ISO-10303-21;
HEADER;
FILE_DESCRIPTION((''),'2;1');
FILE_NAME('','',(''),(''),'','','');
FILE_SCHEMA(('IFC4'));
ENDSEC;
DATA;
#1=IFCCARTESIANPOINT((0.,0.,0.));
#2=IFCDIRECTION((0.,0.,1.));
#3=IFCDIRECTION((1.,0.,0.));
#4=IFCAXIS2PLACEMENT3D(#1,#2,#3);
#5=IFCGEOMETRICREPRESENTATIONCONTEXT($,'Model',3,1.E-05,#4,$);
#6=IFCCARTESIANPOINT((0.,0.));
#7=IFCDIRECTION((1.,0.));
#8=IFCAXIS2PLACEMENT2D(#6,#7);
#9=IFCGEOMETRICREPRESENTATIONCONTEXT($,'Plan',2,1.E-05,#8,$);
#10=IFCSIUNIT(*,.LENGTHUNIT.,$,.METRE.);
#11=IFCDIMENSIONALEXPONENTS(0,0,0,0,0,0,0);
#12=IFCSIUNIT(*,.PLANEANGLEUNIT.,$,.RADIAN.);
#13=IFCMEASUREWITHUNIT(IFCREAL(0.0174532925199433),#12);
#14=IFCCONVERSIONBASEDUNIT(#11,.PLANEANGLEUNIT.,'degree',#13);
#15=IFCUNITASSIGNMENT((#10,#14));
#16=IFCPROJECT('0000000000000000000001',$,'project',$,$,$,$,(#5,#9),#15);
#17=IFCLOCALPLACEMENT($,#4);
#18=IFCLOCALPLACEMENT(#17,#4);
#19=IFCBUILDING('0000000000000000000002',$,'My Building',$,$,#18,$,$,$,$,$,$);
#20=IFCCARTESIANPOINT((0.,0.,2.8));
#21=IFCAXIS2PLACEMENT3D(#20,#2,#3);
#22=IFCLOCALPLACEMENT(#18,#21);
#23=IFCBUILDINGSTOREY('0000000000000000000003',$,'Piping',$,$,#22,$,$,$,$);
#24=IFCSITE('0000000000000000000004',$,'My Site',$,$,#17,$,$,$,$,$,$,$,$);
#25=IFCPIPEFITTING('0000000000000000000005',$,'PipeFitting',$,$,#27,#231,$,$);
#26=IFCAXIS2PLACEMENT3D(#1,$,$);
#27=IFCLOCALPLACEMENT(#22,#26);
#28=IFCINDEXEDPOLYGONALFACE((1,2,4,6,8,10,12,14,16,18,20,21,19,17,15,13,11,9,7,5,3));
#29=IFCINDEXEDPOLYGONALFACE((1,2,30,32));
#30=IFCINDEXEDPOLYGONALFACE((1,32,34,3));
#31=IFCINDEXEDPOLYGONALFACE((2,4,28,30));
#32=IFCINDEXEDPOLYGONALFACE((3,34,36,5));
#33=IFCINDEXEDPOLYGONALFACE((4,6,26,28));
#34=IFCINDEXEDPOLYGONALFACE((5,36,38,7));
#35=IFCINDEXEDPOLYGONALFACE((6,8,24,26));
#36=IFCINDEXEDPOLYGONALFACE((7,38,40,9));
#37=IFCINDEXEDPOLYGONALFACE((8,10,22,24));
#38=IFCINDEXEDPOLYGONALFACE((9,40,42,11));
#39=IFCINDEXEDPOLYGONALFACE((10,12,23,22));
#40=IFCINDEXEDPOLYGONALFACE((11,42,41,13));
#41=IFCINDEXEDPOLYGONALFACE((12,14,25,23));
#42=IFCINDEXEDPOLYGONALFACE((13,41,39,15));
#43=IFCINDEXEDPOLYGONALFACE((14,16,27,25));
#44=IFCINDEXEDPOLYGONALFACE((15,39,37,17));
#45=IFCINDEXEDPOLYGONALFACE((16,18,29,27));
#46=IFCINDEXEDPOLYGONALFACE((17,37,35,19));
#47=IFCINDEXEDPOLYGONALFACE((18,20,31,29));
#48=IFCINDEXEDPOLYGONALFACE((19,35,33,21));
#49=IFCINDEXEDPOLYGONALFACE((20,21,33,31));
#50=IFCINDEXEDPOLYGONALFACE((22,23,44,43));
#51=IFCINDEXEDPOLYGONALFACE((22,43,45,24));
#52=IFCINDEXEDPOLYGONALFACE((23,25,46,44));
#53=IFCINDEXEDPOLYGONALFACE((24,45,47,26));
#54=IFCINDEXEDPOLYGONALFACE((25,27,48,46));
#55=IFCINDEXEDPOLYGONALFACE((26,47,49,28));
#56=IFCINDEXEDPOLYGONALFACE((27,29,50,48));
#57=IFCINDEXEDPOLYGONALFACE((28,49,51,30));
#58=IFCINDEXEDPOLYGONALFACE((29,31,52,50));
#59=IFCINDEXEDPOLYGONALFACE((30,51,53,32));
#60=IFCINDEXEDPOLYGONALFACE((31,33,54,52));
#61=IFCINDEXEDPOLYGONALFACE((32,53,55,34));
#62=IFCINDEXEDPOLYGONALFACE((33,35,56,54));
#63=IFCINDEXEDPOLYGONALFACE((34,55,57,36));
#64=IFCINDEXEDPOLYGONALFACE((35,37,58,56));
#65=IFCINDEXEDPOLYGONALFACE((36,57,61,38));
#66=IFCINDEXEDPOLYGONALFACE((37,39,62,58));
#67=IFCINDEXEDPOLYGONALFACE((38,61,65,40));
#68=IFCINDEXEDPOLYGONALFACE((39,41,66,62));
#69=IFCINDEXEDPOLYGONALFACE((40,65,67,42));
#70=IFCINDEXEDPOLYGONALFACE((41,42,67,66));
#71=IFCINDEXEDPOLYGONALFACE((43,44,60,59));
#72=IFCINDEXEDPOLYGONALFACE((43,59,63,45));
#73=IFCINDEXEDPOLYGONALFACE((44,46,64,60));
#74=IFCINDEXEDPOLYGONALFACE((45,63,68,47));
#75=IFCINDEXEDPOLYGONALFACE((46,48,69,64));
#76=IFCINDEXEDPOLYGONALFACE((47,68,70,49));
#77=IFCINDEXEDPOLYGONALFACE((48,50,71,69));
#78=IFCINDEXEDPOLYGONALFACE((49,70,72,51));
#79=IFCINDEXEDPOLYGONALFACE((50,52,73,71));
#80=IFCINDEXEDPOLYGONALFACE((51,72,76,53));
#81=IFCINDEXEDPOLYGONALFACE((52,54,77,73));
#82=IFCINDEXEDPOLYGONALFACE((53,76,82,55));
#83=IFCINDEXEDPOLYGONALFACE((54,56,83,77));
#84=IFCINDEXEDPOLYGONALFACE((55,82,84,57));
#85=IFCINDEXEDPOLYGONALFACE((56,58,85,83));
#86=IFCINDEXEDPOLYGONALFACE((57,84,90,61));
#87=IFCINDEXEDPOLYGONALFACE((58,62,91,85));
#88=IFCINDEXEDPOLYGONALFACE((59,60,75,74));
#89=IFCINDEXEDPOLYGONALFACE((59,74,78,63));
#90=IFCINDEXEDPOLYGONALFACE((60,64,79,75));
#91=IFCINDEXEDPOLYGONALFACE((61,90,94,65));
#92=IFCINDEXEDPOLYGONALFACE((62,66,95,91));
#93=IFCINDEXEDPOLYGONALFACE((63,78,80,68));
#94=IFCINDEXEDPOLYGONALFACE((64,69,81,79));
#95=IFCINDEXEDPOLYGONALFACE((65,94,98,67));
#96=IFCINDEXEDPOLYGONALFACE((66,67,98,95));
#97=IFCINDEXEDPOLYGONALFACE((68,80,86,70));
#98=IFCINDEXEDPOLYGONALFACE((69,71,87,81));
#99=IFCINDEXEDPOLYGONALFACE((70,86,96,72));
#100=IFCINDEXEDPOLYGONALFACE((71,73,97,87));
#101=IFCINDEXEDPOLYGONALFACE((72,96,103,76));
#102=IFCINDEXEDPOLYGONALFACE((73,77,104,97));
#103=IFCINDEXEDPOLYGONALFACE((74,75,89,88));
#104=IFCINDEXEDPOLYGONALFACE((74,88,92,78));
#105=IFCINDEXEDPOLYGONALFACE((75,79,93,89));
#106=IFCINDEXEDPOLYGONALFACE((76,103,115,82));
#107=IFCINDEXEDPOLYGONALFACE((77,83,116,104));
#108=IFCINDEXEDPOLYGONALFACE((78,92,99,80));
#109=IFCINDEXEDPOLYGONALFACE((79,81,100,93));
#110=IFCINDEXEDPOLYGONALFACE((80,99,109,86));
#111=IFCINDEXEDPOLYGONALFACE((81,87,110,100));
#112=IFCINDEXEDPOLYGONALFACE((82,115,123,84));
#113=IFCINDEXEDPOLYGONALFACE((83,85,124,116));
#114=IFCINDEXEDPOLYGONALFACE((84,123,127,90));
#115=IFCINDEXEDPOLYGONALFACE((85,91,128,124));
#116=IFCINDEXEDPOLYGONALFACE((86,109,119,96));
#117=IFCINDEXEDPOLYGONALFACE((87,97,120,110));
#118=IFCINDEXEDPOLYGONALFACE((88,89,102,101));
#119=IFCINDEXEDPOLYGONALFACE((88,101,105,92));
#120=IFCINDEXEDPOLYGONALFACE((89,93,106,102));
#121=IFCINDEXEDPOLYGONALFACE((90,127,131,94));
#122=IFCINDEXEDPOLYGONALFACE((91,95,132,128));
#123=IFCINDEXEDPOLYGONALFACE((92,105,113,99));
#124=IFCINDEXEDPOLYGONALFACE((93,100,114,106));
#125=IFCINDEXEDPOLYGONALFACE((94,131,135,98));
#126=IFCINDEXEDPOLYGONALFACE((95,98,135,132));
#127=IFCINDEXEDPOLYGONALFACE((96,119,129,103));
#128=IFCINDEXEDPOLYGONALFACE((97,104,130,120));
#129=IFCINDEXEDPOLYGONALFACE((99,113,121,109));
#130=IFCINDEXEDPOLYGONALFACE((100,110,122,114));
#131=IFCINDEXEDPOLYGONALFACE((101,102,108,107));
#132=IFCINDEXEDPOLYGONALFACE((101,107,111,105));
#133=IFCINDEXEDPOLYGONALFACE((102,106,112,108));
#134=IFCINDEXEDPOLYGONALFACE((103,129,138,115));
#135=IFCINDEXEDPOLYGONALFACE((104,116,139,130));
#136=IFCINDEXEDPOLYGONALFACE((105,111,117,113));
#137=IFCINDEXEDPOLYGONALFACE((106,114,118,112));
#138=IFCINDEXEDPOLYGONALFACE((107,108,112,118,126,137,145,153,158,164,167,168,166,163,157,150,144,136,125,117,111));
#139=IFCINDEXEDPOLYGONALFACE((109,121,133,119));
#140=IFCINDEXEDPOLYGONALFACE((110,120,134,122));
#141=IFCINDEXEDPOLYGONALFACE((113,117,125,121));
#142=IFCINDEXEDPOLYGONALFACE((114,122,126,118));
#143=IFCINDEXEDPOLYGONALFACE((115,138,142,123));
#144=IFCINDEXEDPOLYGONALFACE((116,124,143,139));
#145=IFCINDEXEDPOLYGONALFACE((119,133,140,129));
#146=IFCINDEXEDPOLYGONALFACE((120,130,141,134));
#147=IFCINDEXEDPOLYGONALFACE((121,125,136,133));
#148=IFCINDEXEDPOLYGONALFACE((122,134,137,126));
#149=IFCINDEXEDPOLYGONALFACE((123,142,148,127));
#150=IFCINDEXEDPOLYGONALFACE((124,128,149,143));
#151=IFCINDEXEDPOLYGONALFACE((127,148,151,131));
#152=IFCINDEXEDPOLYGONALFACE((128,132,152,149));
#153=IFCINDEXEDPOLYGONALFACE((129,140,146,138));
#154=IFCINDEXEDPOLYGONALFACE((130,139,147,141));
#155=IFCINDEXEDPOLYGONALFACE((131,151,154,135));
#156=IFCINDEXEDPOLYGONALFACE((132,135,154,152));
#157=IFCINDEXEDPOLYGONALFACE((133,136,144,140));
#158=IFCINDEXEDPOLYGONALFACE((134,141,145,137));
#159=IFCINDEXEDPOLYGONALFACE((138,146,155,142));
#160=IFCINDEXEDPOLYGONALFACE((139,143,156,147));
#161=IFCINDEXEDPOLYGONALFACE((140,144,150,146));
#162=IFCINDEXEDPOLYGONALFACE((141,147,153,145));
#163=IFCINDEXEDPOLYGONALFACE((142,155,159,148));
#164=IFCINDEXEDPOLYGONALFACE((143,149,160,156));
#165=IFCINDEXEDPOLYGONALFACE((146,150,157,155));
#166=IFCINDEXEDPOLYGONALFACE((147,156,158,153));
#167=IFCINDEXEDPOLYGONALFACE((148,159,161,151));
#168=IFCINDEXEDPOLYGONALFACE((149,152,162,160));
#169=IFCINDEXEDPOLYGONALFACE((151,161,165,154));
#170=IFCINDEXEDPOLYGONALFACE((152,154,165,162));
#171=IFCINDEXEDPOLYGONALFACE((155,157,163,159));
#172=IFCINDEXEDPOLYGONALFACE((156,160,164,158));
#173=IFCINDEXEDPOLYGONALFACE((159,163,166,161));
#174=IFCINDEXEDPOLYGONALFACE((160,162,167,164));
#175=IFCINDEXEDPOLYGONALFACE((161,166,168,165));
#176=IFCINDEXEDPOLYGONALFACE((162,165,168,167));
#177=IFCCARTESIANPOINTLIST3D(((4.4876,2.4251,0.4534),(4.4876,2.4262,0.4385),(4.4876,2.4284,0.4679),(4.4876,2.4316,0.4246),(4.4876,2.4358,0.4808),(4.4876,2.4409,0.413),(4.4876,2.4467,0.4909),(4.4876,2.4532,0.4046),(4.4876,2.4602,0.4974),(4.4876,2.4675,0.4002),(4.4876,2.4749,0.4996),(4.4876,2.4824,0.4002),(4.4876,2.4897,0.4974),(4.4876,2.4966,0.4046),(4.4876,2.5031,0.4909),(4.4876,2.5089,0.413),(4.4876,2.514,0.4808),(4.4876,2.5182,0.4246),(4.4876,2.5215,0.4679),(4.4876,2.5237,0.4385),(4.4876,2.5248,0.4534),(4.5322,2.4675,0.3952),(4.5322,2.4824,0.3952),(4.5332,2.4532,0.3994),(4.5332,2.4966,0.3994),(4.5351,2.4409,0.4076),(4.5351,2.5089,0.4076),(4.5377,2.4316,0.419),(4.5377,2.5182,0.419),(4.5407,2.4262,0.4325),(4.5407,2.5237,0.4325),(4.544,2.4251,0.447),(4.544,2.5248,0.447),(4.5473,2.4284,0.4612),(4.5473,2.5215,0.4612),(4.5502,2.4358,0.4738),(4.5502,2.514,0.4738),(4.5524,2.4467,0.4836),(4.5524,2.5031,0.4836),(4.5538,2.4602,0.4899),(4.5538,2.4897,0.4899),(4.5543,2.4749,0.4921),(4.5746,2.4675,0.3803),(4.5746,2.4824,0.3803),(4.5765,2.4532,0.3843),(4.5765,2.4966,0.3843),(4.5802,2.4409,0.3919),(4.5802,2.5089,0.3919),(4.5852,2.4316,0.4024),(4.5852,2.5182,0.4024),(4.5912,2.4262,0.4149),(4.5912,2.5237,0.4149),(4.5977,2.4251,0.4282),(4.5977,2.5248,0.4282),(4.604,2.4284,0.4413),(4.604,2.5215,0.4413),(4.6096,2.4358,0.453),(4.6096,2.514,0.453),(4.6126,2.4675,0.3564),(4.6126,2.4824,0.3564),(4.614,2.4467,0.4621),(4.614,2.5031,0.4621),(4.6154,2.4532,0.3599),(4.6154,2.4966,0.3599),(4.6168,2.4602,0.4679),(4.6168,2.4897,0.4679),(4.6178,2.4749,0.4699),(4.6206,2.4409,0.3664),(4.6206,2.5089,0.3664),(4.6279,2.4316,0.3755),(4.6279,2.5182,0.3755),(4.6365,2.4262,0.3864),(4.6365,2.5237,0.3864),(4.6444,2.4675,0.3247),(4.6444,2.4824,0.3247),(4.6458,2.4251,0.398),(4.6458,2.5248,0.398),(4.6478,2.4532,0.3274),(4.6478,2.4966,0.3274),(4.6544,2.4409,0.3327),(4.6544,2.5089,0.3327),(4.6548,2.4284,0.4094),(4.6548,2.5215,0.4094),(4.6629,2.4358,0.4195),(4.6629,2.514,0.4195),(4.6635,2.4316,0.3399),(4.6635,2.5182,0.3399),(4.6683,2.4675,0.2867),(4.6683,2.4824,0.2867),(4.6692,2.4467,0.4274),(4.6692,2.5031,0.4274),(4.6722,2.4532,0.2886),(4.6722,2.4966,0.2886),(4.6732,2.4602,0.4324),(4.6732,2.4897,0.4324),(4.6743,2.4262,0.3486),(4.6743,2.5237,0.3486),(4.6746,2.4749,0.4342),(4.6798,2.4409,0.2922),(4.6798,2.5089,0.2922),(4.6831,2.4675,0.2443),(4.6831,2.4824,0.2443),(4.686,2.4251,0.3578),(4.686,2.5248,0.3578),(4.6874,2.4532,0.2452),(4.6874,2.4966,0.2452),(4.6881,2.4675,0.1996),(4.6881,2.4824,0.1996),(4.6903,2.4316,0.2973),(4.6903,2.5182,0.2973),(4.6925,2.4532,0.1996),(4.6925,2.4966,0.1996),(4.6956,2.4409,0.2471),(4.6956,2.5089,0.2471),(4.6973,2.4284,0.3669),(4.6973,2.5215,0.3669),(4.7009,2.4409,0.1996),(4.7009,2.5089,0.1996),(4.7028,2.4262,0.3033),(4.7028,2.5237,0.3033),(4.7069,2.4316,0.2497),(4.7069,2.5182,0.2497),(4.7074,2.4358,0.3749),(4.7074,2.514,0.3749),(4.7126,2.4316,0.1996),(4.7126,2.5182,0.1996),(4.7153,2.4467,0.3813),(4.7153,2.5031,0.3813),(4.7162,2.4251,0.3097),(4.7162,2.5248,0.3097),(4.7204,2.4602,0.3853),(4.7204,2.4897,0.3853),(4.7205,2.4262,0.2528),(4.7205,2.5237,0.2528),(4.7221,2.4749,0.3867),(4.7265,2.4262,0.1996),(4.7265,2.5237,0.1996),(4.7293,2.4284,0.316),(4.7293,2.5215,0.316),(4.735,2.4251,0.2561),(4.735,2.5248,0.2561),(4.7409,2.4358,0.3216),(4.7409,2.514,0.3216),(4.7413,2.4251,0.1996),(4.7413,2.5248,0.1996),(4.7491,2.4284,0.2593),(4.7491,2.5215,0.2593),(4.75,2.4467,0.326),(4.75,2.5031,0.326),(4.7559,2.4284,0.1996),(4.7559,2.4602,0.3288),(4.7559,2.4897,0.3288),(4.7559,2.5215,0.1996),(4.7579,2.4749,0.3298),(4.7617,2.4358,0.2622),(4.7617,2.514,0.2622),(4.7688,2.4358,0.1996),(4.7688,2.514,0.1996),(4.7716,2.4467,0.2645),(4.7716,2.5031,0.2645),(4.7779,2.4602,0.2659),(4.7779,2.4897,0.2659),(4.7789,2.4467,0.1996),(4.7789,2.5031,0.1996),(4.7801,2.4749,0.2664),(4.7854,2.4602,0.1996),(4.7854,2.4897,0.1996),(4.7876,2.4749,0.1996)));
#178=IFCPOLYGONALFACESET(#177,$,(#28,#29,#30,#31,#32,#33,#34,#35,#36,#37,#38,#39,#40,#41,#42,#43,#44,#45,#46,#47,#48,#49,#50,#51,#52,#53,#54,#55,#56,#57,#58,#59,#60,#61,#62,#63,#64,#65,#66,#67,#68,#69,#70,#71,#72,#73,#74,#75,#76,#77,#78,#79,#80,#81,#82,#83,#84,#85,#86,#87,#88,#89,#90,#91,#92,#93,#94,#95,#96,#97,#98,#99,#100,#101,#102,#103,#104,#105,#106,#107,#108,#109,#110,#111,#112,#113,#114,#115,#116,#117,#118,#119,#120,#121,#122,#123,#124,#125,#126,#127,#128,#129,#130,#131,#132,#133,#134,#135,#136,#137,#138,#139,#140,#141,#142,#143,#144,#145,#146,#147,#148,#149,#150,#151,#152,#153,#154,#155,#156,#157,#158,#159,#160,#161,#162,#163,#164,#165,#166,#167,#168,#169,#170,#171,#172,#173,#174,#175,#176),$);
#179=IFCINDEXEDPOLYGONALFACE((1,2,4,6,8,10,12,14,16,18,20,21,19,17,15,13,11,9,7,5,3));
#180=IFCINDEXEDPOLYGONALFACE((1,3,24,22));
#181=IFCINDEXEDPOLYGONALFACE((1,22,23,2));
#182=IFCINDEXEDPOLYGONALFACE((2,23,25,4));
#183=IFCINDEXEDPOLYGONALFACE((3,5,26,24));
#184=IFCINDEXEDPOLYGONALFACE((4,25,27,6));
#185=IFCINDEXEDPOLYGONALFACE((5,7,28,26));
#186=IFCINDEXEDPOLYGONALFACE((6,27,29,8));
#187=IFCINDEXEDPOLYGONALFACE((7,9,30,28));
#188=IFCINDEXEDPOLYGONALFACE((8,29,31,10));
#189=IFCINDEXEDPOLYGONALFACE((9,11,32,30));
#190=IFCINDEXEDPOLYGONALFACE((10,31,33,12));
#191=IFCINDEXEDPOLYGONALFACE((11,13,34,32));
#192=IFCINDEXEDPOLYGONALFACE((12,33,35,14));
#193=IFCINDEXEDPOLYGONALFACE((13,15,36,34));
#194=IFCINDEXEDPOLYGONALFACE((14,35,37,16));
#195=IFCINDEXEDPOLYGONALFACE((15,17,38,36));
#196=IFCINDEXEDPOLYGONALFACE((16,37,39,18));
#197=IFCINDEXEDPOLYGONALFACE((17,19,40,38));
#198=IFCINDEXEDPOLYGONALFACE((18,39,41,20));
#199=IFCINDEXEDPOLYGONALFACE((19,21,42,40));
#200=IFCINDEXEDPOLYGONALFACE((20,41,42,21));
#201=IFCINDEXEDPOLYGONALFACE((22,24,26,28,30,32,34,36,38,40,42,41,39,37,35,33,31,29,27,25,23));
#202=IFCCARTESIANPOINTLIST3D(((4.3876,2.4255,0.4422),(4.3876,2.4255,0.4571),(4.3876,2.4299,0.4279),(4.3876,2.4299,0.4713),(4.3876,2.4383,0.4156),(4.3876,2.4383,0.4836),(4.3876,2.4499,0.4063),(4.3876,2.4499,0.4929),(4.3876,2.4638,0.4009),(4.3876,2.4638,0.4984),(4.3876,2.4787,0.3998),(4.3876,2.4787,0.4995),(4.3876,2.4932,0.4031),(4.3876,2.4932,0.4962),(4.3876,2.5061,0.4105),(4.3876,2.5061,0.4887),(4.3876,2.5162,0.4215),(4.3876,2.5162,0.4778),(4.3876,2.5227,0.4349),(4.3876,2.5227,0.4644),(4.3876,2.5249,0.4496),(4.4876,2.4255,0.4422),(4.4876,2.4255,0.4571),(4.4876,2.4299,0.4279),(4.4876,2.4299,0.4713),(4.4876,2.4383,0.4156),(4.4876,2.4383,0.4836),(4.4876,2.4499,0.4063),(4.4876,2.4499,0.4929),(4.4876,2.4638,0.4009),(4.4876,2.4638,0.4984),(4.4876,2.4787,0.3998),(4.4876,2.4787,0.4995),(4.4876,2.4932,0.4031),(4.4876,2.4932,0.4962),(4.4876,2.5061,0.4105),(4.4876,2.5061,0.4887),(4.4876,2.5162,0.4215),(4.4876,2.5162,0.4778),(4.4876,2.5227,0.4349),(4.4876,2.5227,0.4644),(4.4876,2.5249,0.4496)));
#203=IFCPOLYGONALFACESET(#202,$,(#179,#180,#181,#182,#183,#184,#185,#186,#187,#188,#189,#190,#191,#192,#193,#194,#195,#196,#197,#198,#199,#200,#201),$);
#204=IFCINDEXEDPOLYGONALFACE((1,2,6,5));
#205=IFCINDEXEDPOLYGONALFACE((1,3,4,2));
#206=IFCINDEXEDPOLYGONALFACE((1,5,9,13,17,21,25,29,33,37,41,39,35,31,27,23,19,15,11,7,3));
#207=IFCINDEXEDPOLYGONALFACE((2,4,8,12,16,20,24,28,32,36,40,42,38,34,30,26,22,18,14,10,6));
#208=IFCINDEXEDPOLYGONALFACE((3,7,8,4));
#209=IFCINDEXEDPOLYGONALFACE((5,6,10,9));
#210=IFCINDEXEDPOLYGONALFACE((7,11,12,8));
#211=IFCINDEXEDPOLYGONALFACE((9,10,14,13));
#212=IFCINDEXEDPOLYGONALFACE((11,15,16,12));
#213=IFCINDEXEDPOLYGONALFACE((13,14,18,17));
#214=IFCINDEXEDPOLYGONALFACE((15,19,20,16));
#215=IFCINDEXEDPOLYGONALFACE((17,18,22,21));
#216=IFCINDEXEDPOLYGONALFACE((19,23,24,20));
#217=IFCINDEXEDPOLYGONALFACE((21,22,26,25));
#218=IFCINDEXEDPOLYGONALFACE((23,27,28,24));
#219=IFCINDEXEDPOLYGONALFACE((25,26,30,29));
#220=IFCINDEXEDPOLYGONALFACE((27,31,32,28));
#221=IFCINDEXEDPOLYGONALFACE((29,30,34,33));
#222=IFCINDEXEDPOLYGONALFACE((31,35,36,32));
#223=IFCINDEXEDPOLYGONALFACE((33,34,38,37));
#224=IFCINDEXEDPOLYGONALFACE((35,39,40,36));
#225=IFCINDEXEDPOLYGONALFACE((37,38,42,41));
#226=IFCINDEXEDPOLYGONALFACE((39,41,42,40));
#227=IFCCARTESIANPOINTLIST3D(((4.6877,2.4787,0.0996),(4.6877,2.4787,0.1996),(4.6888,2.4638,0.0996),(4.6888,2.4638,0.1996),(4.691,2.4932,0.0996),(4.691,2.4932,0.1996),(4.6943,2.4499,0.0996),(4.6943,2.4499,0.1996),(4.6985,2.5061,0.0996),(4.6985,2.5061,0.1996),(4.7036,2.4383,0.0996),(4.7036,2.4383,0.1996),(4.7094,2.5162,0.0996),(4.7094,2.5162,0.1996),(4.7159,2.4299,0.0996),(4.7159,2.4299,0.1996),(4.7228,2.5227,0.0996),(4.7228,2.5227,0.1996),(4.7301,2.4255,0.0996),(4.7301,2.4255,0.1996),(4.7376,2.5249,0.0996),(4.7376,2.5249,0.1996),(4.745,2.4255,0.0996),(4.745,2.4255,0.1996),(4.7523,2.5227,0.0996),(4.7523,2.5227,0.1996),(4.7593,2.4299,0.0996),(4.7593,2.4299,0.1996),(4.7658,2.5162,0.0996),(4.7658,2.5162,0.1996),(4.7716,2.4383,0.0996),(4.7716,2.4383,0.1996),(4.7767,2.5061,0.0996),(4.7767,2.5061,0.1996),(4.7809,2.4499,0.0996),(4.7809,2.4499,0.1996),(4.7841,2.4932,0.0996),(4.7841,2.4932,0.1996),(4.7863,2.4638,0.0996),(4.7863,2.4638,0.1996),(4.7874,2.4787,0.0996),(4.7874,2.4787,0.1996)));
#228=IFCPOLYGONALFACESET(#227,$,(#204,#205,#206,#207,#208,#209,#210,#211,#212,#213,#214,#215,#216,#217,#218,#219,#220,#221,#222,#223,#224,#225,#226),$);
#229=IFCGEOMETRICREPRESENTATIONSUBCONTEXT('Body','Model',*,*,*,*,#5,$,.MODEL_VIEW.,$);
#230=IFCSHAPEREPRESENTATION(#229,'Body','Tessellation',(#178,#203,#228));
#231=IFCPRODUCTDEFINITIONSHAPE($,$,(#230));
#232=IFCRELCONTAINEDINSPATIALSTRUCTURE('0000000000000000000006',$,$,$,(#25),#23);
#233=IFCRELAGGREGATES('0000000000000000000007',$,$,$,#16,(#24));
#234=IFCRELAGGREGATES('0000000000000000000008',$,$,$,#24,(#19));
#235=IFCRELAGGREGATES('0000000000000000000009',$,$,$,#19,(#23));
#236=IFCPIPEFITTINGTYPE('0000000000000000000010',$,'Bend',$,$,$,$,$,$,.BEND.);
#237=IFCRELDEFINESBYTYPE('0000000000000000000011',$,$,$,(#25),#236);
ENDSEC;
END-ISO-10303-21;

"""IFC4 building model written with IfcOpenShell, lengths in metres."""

from ifc_helpers import new_model, entity, si_unit, converted_unit, frame, origin_with_axes, origin_2d_with_axis, place, context, subcontext, project, spatial, circle, extrude, source, transform, mapped, type_object, type_shapes, element, save


model = new_model("IFC4")

# Units and contexts
model_context = context("Model", 3, precision=1e-05, world=origin_with_axes())
plan_context = context("Plan", 2, precision=1e-05, world=origin_2d_with_axis())
body_context = subcontext(model_context, "Body", "Model", "MODEL_VIEW")
ifc_project = project(units=[si_unit("LENGTHUNIT", "METRE"), converted_unit("PLANEANGLEUNIT", "degree", entity("IfcReal", 0.0174532925199433), si_unit("PLANEANGLEUNIT", "RADIAN"), dimensions=[0, 0, 0, 0, 0, 0, 0])], contexts=[model_context, plan_context])

# Site, building, storey
site_placement = place(None, origin_with_axes())
site = spatial("IfcSite", under=ifc_project, at=site_placement, Name="My Site")
building_placement = place(site_placement, origin_with_axes())
building = spatial("IfcBuilding", under=site, at=building_placement, Name="My Building")
storey_placement = place(building_placement, frame((0.0, 0.0, 2.8), z_axis=(0.0, 0.0, 1.0), x_axis=(1.0, 0.0, 0.0)))
storey = spatial("IfcBuildingStorey", under=building, at=storey_placement, Name="Piping")

# Pipe fitting
pipe_fitting_type_1 = type_object("IfcPipeFittingType", Name="Bend", PredefinedType="BEND")
shared_shape_1 = source(origin_with_axes(), body_context, "Body", "SolidModel", [
    entity("IfcSweptDiskSolid", entity("IfcIndexedPolyCurve", entity("IfcCartesianPointList3D", [[0.0, 0.0, 0.1], [0.0, -0.0732, 0.2768], [0.0, -0.25, 0.35]]), [entity("IfcArcIndex", [1, 2, 3])]), 0.05),
    extrude(circle(Radius=0.05), origin_with_axes(), (0.0, 0.0, 1.0), 0.1),
    extrude(circle(Radius=0.05), frame((0.0, -0.25, 0.35), z_axis=(0.0, -1.0, 0.0), x_axis=(1.0, 0.0, 0.0)), (0.0, 0.0, 1.0), 0.1),
])
type_shapes(pipe_fitting_type_1, [shared_shape_1])
for number, where, z_axis, x_axis, name in (
    (1, (4.3876, 2.4749, 0.4496), (1.0, 0.0, 0.0), (0.0, 1.0, 0.0), "PipeFitting"),
):
    element("IfcPipeFitting", number, at=place(storey_placement, frame(where, z_axis=z_axis, x_axis=x_axis)), inside=storey, type_object=pipe_fitting_type_1, Name=name, context=body_context, shape_type="MappedRepresentation", body=[
        mapped(shared_shape_1, transform((0.0, 0.0, 0.0), x_axis=(1.0, 0.0, 0.0), y_axis=(0.0, 1.0, 0.0), z_axis=(0.0, 0.0, 1.0), scale=1.0)),
    ])

save(model, "model.ifc")
